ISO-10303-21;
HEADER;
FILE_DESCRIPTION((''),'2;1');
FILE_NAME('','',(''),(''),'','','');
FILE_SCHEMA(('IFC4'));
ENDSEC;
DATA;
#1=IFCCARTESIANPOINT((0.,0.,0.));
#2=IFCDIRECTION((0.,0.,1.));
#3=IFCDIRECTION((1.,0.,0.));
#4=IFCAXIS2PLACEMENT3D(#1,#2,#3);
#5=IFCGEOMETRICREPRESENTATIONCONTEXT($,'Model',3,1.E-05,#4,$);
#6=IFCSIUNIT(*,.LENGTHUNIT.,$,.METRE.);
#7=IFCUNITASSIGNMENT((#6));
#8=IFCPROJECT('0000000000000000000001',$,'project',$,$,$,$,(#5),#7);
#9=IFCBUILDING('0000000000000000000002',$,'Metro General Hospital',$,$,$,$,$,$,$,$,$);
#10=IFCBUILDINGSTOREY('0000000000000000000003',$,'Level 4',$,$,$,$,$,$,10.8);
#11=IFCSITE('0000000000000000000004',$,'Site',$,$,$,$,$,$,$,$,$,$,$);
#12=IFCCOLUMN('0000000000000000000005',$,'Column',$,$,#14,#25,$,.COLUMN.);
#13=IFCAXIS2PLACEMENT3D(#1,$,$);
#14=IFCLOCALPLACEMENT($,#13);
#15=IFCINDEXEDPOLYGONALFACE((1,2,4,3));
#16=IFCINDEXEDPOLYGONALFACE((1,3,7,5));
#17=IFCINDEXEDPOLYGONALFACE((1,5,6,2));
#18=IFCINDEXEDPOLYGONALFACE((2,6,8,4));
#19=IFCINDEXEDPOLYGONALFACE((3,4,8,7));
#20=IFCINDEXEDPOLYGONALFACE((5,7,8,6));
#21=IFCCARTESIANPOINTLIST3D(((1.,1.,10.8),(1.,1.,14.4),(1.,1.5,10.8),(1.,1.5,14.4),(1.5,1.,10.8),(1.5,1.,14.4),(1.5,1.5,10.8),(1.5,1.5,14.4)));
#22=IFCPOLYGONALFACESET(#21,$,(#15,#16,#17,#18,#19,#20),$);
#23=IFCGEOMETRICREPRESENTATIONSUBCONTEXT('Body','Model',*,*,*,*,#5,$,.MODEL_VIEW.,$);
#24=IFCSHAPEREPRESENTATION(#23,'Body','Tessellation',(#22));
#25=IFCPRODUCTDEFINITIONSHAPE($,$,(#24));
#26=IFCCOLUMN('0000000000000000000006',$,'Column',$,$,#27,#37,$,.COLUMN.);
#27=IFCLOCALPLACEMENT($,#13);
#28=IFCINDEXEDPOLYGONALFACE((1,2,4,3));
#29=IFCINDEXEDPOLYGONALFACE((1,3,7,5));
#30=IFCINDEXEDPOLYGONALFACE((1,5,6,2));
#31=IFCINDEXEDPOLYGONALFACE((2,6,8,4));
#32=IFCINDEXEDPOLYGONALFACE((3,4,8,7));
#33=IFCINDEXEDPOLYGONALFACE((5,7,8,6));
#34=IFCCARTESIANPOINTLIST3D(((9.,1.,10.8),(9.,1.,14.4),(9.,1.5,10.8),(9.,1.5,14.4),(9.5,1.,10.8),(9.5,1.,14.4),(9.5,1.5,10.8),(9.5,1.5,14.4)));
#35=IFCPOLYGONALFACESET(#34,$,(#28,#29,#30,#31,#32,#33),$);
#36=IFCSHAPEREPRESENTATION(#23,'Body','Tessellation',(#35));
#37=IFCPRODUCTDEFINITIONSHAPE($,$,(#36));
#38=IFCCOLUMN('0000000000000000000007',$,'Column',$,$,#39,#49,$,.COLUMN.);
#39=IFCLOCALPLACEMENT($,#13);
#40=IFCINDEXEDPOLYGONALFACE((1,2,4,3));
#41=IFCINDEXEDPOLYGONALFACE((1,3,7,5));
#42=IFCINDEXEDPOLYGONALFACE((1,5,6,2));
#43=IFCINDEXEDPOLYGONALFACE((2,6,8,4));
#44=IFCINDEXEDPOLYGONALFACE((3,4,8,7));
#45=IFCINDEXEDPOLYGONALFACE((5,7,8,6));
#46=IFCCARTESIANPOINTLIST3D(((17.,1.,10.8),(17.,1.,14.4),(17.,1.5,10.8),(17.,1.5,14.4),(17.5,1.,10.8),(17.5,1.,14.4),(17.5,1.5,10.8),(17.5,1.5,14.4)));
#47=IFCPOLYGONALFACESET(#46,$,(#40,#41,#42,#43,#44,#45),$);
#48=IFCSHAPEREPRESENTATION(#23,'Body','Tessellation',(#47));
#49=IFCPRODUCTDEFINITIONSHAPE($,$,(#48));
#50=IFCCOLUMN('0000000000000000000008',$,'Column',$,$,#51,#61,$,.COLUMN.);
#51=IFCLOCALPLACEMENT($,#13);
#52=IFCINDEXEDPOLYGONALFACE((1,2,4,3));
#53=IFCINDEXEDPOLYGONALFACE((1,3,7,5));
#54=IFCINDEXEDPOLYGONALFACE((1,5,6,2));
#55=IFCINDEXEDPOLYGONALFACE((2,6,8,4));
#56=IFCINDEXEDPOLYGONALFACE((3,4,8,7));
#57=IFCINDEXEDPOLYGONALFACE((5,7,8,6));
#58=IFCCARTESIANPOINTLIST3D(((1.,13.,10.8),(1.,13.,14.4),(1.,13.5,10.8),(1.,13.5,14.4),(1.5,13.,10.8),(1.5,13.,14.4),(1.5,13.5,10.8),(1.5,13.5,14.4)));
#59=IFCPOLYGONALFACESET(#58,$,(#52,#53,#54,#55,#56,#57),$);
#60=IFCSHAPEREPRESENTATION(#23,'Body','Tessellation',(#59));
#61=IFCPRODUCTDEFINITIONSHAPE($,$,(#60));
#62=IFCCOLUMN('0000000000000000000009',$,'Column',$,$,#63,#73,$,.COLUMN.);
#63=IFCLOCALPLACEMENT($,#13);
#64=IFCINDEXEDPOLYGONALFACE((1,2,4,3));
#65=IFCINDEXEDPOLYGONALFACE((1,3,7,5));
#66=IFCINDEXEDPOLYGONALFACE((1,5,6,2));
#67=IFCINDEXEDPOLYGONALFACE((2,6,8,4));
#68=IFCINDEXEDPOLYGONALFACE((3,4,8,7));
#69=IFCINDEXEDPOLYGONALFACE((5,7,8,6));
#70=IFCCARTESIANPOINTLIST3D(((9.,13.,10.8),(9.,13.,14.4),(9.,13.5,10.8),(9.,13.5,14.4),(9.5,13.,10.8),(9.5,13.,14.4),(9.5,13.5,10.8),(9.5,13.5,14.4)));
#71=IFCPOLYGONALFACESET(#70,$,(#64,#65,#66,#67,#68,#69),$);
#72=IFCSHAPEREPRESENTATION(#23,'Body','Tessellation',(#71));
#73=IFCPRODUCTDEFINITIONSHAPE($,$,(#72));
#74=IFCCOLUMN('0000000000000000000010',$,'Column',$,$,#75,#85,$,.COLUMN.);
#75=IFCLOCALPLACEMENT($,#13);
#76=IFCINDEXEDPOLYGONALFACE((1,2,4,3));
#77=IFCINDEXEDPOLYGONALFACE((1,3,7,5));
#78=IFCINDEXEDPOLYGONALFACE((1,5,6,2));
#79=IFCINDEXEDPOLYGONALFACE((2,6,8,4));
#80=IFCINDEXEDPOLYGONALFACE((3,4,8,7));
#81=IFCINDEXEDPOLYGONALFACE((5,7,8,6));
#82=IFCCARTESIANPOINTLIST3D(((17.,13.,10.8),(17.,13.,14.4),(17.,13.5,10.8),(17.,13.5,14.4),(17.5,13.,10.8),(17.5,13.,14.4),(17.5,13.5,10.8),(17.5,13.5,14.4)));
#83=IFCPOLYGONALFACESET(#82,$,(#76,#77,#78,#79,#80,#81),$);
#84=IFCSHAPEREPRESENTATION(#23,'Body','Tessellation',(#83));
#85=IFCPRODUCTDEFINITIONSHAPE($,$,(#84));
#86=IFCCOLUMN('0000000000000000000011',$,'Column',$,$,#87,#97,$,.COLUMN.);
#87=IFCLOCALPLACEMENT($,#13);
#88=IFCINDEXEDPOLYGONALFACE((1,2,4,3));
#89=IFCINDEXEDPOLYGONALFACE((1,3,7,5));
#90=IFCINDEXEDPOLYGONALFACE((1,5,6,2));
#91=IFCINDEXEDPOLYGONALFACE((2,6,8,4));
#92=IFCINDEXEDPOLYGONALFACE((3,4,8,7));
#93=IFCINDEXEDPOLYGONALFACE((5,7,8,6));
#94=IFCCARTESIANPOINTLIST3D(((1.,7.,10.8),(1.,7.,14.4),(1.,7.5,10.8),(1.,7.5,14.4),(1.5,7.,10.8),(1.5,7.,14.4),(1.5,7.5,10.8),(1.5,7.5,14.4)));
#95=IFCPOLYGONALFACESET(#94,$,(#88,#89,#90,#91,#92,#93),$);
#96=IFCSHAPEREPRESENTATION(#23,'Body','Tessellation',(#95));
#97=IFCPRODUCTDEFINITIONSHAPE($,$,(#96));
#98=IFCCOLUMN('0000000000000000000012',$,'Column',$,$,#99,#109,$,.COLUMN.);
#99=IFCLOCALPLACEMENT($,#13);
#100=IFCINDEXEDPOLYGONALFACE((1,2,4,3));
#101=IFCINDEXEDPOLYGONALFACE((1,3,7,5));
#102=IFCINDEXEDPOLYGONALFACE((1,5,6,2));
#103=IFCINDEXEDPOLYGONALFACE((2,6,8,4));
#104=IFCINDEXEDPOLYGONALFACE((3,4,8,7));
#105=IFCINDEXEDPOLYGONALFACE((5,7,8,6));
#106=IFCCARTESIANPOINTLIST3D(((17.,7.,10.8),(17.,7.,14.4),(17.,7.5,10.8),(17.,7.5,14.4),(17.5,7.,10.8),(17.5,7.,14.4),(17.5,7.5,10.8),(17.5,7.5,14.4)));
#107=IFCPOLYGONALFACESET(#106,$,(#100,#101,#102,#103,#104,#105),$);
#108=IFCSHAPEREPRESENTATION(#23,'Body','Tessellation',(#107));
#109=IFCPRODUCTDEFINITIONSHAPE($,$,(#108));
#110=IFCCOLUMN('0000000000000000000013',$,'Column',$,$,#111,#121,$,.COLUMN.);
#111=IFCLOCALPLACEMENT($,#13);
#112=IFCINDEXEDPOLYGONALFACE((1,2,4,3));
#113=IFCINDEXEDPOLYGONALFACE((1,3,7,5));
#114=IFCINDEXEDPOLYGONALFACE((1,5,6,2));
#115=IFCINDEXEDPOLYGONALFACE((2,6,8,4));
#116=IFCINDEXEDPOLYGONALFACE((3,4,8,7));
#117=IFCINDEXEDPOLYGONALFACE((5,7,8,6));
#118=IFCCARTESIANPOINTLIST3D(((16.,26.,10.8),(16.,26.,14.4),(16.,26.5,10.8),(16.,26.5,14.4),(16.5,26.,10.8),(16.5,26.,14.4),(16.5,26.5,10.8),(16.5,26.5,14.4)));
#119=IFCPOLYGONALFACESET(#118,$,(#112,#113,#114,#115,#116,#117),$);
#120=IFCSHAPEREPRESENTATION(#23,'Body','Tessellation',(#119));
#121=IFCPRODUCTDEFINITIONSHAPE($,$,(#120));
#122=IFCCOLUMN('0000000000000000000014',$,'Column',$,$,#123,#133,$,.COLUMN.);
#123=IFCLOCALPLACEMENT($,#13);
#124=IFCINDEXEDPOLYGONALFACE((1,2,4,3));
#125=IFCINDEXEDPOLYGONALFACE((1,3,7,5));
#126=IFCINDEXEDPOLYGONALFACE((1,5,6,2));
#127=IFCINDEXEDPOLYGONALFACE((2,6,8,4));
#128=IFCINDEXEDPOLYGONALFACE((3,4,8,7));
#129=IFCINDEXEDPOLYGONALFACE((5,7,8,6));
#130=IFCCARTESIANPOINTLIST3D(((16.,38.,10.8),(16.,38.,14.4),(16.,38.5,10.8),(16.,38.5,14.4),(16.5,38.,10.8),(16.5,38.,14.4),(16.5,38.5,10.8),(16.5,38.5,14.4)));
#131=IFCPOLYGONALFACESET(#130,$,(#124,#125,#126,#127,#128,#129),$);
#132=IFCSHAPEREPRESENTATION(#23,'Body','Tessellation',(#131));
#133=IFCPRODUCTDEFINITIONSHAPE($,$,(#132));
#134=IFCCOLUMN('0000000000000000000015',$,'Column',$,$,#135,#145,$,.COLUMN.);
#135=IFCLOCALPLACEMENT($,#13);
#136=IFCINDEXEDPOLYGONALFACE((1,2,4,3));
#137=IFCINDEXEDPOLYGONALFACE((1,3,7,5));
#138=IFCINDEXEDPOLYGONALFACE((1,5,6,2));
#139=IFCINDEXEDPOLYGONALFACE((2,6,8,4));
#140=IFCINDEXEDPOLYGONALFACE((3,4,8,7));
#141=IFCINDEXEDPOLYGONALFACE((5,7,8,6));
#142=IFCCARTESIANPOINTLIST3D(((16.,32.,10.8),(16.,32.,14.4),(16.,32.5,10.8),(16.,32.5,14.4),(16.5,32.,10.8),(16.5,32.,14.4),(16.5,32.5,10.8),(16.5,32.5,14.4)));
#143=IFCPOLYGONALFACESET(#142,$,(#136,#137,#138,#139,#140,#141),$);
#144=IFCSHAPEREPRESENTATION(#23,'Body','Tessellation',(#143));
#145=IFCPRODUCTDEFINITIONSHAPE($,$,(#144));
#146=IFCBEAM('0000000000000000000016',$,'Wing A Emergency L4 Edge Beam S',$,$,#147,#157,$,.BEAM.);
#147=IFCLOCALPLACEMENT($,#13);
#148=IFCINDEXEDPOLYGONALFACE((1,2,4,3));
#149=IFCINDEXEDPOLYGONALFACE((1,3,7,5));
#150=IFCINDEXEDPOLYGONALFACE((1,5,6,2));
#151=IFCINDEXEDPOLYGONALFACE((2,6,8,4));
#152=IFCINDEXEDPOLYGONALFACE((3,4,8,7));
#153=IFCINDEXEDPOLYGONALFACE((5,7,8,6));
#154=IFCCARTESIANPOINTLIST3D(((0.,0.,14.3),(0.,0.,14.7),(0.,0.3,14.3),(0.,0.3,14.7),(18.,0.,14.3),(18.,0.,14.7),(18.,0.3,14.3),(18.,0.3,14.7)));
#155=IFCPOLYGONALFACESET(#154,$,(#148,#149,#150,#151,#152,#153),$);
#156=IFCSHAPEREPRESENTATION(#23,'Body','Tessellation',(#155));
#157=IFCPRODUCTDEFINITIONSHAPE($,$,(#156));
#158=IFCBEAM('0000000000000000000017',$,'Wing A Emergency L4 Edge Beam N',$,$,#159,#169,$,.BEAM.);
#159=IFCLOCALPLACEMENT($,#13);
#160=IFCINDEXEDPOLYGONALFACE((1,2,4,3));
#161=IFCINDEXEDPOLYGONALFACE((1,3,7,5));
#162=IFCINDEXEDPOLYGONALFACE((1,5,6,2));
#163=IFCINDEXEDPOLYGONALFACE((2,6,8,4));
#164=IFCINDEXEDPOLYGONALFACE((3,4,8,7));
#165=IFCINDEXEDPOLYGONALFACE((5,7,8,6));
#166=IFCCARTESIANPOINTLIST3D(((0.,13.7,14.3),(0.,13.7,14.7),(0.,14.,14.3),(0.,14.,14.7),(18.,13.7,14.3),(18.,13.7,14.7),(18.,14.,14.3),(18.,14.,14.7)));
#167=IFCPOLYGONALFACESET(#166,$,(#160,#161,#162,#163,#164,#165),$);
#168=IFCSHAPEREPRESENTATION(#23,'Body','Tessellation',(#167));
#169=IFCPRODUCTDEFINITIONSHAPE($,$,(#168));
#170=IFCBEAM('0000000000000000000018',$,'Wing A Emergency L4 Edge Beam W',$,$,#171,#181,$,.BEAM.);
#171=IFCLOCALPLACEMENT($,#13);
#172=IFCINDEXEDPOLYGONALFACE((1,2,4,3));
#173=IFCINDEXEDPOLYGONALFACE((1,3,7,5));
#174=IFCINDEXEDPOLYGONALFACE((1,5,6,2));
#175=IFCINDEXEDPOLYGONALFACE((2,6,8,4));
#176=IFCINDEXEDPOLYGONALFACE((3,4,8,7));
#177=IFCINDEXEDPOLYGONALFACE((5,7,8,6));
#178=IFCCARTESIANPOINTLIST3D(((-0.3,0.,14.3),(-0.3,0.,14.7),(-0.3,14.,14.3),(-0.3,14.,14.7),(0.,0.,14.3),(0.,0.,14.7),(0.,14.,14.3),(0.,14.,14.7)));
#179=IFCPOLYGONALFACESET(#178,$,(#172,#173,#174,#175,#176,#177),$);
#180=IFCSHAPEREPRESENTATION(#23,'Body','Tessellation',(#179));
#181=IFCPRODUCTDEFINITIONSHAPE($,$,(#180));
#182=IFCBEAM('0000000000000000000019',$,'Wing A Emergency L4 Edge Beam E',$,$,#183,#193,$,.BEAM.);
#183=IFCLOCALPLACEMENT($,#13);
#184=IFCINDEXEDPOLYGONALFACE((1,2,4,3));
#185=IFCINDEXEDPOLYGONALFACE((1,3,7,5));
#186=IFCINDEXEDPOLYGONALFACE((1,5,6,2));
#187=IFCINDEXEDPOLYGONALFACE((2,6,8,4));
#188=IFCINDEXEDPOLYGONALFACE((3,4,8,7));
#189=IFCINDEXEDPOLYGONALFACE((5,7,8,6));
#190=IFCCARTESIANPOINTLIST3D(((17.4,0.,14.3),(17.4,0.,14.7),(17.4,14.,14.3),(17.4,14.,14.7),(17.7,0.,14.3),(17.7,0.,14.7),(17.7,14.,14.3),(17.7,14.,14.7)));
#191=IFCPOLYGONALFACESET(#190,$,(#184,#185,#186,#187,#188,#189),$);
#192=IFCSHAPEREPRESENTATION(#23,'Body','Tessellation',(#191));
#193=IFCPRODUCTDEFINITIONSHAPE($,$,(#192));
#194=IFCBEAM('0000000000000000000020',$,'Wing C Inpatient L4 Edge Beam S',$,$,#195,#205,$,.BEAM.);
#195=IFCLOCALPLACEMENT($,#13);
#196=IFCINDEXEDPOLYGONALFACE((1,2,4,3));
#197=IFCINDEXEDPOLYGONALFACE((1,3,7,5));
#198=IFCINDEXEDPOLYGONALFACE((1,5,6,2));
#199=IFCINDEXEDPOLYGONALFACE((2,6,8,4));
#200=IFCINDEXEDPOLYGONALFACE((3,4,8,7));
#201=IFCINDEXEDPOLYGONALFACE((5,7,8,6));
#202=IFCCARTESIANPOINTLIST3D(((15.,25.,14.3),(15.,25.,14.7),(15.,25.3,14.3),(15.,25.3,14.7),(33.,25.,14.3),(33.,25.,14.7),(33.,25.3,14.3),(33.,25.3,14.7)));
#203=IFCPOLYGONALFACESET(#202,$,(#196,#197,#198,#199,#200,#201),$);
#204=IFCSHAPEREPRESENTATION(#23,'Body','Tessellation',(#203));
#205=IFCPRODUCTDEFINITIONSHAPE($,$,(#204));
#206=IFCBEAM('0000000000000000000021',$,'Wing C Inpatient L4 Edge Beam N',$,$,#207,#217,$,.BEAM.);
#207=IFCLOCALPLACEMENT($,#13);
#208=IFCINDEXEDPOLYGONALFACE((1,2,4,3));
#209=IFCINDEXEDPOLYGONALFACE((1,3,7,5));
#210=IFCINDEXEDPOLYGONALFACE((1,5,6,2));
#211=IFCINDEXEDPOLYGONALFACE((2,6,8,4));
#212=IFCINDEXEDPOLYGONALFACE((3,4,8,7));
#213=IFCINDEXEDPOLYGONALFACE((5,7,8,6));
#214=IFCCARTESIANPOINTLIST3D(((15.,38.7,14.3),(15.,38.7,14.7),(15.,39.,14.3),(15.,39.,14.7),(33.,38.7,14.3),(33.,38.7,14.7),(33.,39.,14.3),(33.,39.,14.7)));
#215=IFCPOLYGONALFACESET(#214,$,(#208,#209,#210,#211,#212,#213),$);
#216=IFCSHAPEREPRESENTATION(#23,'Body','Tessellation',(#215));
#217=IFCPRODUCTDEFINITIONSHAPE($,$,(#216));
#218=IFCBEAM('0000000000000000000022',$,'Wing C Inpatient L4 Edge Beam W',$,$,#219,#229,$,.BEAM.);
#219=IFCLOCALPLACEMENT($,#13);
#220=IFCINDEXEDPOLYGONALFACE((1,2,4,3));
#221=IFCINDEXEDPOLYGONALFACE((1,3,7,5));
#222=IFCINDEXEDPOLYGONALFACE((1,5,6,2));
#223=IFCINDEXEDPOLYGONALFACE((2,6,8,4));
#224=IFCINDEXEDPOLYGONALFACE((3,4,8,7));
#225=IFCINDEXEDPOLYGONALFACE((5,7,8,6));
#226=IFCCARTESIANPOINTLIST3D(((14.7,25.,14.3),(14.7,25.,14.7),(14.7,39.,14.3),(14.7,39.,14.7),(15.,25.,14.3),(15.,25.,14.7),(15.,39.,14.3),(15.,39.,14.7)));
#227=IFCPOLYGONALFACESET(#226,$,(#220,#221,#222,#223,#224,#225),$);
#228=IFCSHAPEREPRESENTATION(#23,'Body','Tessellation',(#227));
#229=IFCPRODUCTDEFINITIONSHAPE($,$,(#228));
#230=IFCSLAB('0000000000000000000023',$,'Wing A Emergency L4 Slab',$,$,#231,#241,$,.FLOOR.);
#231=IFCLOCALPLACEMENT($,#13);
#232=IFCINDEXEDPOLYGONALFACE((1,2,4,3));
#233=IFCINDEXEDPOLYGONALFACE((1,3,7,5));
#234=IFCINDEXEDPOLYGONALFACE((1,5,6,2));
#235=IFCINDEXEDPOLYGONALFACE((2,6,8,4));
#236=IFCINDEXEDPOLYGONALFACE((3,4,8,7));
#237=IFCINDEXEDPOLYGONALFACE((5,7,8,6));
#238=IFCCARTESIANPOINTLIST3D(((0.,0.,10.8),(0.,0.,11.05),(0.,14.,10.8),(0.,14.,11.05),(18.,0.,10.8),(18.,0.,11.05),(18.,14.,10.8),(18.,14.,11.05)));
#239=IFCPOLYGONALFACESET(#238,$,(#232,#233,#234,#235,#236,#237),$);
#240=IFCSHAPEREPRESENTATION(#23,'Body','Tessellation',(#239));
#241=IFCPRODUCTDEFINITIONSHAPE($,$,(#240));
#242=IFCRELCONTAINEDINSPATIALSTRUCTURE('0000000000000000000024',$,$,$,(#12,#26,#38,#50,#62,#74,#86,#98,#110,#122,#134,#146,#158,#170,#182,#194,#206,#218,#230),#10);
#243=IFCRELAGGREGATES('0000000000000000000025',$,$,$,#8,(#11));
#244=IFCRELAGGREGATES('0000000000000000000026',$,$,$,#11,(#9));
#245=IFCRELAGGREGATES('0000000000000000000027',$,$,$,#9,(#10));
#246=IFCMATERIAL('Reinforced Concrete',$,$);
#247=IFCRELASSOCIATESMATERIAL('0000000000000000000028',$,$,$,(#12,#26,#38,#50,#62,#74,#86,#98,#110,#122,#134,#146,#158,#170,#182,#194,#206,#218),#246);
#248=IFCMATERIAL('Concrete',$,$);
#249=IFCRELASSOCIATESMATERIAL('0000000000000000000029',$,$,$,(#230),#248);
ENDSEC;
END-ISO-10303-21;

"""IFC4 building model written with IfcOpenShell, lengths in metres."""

from ifc_helpers import new_model, si_unit, frame, origin_with_axes, place, context, subcontext, project, spatial, line, indexed_curve, outline, extrude, material, element, save


model = new_model("IFC4")

# Units and contexts
model_context = context("Model", 3, precision=1e-05, world=origin_with_axes())
body_context = subcontext(model_context, "Body", "Model", "MODEL_VIEW")
ifc_project = project(units=[si_unit("LENGTHUNIT", "METRE")], contexts=[model_context])

# Site, building, storey
site = spatial("IfcSite", under=ifc_project, Name="Site")
building = spatial("IfcBuilding", under=site, Name="Metro General Hospital")
storey = spatial("IfcBuildingStorey", under=building, Name="Level 4", Elevation=10.8)

# Columns
ifc_material_1 = material(Name="Reinforced Concrete")
for number, where, z_axis, x_axis, name in (
    (1, (1.0, 1.0, 10.8), (0.0, 0.0, 1.0), (1.0, 0.0, 0.0), "Column"),
    (2, (9.0, 1.0, 10.8), (0.0, 0.0, 1.0), (1.0, 0.0, 0.0), "Column"),
    (3, (17.0, 1.0, 10.8), (0.0, 0.0, 1.0), (1.0, 0.0, 0.0), "Column"),
    (4, (1.0, 13.0, 10.8), (0.0, 0.0, 1.0), (1.0, 0.0, 0.0), "Column"),
    (5, (9.0, 13.0, 10.8), (0.0, 0.0, 1.0), (1.0, 0.0, 0.0), "Column"),
    (6, (17.0, 13.0, 10.8), (0.0, 0.0, 1.0), (1.0, 0.0, 0.0), "Column"),
    (7, (1.0, 7.0, 10.8), (0.0, 0.0, 1.0), (1.0, 0.0, 0.0), "Column"),
    (8, (17.0, 7.0, 10.8), (0.0, 0.0, 1.0), (1.0, 0.0, 0.0), "Column"),
    (9, (16.0, 26.0, 10.8), (0.0, 0.0, 1.0), (1.0, 0.0, 0.0), "Column"),
    (10, (16.0, 38.0, 10.8), (0.0, 0.0, 1.0), (1.0, 0.0, 0.0), "Column"),
    (11, (16.0, 32.0, 10.8), (0.0, 0.0, 1.0), (1.0, 0.0, 0.0), "Column"),
):
    element("IfcColumn", number, at=place(None, frame(where, z_axis=z_axis, x_axis=x_axis)), inside=storey, material=ifc_material_1, Name=name, PredefinedType="COLUMN", context=body_context, shape_type="SweptSolid", body=[
        extrude(outline(indexed_curve([(0.0, 0.0), (0.5, 0.0), (0.5, 0.5), (0.0, 0.5)], segments=[line(1, 2, 3, 4, 1)])), origin_with_axes(), (0.0, 0.0, 1.0), 3.6),
    ])

# Beams
for number, where, z_axis, x_axis, name in (
    (12, (0.0, 0.0, 14.3), (0.0, 0.0, 1.0), (1.0, 0.0, 0.0), "Wing A Emergency L4 Edge Beam S"),
    (13, (0.0, 13.7, 14.3), (0.0, 0.0, 1.0), (1.0, 0.0, 0.0), "Wing A Emergency L4 Edge Beam N"),
):
    element("IfcBeam", number, at=place(None, frame(where, z_axis=z_axis, x_axis=x_axis)), inside=storey, material=ifc_material_1, Name=name, PredefinedType="BEAM", context=body_context, shape_type="SweptSolid", body=[
        extrude(outline(indexed_curve([(0.0, 0.0), (18.0, 0.0), (18.0, 0.3), (0.0, 0.3)], segments=[line(1, 2, 3, 4, 1)])), origin_with_axes(), (0.0, 0.0, 1.0), 0.4),
    ])
for number, where, z_axis, x_axis, name in (
    (14, (0.0, 0.0, 14.3), (0.0, 0.0, 1.0), (0.0, 1.0, 0.0), "Wing A Emergency L4 Edge Beam W"),
    (15, (17.7, 0.0, 14.3), (0.0, 0.0, 1.0), (0.0, 1.0, 0.0), "Wing A Emergency L4 Edge Beam E"),
):
    element("IfcBeam", number, at=place(None, frame(where, z_axis=z_axis, x_axis=x_axis)), inside=storey, material=ifc_material_1, Name=name, PredefinedType="BEAM", context=body_context, shape_type="SweptSolid", body=[
        extrude(outline(indexed_curve([(0.0, 0.0), (14.0, 0.0), (14.0, 0.3), (0.0, 0.3)], segments=[line(1, 2, 3, 4, 1)])), origin_with_axes(), (0.0, 0.0, 1.0), 0.4),
    ])
for number, where, z_axis, x_axis, name in (
    (16, (15.0, 25.0, 14.3), (0.0, 0.0, 1.0), (1.0, 0.0, 0.0), "Wing C Inpatient L4 Edge Beam S"),
    (17, (15.0, 38.7, 14.3), (0.0, 0.0, 1.0), (1.0, 0.0, 0.0), "Wing C Inpatient L4 Edge Beam N"),
):
    element("IfcBeam", number, at=place(None, frame(where, z_axis=z_axis, x_axis=x_axis)), inside=storey, material=ifc_material_1, Name=name, PredefinedType="BEAM", context=body_context, shape_type="SweptSolid", body=[
        extrude(outline(indexed_curve([(0.0, 0.0), (18.0, 0.0), (18.0, 0.3), (0.0, 0.3)], segments=[line(1, 2, 3, 4, 1)])), origin_with_axes(), (0.0, 0.0, 1.0), 0.4),
    ])
beam_placement = place(None, frame((15.0, 25.0, 14.3), z_axis=(0.0, 0.0, 1.0), x_axis=(0.0, 1.0, 0.0)))
element("IfcBeam", 18, at=beam_placement, inside=storey, material=ifc_material_1, Name="Wing C Inpatient L4 Edge Beam W", PredefinedType="BEAM", context=body_context, shape_type="SweptSolid", body=[
    extrude(outline(indexed_curve([(0.0, 0.0), (14.0, 0.0), (14.0, 0.3), (0.0, 0.3)], segments=[line(1, 2, 3, 4, 1)])), origin_with_axes(), (0.0, 0.0, 1.0), 0.4),
])

# Slab
ifc_material_2 = material(Name="Concrete")
for number, where, z_axis, x_axis, name in (
    (19, (0.0, 0.0, 10.8), (0.0, 0.0, 1.0), (1.0, 0.0, 0.0), "Wing A Emergency L4 Slab"),
):
    element("IfcSlab", number, at=place(None, frame(where, z_axis=z_axis, x_axis=x_axis)), inside=storey, material=ifc_material_2, Name=name, PredefinedType="FLOOR", context=body_context, shape_type="SweptSolid", body=[
        extrude(outline(indexed_curve([(0.0, 0.0), (18.0, 0.0), (18.0, 14.0), (0.0, 14.0)], segments=[line(1, 2, 3, 4, 1)])), origin_with_axes(), (0.0, 0.0, 1.0), 0.25),
    ])

save(model, "model.ifc")
